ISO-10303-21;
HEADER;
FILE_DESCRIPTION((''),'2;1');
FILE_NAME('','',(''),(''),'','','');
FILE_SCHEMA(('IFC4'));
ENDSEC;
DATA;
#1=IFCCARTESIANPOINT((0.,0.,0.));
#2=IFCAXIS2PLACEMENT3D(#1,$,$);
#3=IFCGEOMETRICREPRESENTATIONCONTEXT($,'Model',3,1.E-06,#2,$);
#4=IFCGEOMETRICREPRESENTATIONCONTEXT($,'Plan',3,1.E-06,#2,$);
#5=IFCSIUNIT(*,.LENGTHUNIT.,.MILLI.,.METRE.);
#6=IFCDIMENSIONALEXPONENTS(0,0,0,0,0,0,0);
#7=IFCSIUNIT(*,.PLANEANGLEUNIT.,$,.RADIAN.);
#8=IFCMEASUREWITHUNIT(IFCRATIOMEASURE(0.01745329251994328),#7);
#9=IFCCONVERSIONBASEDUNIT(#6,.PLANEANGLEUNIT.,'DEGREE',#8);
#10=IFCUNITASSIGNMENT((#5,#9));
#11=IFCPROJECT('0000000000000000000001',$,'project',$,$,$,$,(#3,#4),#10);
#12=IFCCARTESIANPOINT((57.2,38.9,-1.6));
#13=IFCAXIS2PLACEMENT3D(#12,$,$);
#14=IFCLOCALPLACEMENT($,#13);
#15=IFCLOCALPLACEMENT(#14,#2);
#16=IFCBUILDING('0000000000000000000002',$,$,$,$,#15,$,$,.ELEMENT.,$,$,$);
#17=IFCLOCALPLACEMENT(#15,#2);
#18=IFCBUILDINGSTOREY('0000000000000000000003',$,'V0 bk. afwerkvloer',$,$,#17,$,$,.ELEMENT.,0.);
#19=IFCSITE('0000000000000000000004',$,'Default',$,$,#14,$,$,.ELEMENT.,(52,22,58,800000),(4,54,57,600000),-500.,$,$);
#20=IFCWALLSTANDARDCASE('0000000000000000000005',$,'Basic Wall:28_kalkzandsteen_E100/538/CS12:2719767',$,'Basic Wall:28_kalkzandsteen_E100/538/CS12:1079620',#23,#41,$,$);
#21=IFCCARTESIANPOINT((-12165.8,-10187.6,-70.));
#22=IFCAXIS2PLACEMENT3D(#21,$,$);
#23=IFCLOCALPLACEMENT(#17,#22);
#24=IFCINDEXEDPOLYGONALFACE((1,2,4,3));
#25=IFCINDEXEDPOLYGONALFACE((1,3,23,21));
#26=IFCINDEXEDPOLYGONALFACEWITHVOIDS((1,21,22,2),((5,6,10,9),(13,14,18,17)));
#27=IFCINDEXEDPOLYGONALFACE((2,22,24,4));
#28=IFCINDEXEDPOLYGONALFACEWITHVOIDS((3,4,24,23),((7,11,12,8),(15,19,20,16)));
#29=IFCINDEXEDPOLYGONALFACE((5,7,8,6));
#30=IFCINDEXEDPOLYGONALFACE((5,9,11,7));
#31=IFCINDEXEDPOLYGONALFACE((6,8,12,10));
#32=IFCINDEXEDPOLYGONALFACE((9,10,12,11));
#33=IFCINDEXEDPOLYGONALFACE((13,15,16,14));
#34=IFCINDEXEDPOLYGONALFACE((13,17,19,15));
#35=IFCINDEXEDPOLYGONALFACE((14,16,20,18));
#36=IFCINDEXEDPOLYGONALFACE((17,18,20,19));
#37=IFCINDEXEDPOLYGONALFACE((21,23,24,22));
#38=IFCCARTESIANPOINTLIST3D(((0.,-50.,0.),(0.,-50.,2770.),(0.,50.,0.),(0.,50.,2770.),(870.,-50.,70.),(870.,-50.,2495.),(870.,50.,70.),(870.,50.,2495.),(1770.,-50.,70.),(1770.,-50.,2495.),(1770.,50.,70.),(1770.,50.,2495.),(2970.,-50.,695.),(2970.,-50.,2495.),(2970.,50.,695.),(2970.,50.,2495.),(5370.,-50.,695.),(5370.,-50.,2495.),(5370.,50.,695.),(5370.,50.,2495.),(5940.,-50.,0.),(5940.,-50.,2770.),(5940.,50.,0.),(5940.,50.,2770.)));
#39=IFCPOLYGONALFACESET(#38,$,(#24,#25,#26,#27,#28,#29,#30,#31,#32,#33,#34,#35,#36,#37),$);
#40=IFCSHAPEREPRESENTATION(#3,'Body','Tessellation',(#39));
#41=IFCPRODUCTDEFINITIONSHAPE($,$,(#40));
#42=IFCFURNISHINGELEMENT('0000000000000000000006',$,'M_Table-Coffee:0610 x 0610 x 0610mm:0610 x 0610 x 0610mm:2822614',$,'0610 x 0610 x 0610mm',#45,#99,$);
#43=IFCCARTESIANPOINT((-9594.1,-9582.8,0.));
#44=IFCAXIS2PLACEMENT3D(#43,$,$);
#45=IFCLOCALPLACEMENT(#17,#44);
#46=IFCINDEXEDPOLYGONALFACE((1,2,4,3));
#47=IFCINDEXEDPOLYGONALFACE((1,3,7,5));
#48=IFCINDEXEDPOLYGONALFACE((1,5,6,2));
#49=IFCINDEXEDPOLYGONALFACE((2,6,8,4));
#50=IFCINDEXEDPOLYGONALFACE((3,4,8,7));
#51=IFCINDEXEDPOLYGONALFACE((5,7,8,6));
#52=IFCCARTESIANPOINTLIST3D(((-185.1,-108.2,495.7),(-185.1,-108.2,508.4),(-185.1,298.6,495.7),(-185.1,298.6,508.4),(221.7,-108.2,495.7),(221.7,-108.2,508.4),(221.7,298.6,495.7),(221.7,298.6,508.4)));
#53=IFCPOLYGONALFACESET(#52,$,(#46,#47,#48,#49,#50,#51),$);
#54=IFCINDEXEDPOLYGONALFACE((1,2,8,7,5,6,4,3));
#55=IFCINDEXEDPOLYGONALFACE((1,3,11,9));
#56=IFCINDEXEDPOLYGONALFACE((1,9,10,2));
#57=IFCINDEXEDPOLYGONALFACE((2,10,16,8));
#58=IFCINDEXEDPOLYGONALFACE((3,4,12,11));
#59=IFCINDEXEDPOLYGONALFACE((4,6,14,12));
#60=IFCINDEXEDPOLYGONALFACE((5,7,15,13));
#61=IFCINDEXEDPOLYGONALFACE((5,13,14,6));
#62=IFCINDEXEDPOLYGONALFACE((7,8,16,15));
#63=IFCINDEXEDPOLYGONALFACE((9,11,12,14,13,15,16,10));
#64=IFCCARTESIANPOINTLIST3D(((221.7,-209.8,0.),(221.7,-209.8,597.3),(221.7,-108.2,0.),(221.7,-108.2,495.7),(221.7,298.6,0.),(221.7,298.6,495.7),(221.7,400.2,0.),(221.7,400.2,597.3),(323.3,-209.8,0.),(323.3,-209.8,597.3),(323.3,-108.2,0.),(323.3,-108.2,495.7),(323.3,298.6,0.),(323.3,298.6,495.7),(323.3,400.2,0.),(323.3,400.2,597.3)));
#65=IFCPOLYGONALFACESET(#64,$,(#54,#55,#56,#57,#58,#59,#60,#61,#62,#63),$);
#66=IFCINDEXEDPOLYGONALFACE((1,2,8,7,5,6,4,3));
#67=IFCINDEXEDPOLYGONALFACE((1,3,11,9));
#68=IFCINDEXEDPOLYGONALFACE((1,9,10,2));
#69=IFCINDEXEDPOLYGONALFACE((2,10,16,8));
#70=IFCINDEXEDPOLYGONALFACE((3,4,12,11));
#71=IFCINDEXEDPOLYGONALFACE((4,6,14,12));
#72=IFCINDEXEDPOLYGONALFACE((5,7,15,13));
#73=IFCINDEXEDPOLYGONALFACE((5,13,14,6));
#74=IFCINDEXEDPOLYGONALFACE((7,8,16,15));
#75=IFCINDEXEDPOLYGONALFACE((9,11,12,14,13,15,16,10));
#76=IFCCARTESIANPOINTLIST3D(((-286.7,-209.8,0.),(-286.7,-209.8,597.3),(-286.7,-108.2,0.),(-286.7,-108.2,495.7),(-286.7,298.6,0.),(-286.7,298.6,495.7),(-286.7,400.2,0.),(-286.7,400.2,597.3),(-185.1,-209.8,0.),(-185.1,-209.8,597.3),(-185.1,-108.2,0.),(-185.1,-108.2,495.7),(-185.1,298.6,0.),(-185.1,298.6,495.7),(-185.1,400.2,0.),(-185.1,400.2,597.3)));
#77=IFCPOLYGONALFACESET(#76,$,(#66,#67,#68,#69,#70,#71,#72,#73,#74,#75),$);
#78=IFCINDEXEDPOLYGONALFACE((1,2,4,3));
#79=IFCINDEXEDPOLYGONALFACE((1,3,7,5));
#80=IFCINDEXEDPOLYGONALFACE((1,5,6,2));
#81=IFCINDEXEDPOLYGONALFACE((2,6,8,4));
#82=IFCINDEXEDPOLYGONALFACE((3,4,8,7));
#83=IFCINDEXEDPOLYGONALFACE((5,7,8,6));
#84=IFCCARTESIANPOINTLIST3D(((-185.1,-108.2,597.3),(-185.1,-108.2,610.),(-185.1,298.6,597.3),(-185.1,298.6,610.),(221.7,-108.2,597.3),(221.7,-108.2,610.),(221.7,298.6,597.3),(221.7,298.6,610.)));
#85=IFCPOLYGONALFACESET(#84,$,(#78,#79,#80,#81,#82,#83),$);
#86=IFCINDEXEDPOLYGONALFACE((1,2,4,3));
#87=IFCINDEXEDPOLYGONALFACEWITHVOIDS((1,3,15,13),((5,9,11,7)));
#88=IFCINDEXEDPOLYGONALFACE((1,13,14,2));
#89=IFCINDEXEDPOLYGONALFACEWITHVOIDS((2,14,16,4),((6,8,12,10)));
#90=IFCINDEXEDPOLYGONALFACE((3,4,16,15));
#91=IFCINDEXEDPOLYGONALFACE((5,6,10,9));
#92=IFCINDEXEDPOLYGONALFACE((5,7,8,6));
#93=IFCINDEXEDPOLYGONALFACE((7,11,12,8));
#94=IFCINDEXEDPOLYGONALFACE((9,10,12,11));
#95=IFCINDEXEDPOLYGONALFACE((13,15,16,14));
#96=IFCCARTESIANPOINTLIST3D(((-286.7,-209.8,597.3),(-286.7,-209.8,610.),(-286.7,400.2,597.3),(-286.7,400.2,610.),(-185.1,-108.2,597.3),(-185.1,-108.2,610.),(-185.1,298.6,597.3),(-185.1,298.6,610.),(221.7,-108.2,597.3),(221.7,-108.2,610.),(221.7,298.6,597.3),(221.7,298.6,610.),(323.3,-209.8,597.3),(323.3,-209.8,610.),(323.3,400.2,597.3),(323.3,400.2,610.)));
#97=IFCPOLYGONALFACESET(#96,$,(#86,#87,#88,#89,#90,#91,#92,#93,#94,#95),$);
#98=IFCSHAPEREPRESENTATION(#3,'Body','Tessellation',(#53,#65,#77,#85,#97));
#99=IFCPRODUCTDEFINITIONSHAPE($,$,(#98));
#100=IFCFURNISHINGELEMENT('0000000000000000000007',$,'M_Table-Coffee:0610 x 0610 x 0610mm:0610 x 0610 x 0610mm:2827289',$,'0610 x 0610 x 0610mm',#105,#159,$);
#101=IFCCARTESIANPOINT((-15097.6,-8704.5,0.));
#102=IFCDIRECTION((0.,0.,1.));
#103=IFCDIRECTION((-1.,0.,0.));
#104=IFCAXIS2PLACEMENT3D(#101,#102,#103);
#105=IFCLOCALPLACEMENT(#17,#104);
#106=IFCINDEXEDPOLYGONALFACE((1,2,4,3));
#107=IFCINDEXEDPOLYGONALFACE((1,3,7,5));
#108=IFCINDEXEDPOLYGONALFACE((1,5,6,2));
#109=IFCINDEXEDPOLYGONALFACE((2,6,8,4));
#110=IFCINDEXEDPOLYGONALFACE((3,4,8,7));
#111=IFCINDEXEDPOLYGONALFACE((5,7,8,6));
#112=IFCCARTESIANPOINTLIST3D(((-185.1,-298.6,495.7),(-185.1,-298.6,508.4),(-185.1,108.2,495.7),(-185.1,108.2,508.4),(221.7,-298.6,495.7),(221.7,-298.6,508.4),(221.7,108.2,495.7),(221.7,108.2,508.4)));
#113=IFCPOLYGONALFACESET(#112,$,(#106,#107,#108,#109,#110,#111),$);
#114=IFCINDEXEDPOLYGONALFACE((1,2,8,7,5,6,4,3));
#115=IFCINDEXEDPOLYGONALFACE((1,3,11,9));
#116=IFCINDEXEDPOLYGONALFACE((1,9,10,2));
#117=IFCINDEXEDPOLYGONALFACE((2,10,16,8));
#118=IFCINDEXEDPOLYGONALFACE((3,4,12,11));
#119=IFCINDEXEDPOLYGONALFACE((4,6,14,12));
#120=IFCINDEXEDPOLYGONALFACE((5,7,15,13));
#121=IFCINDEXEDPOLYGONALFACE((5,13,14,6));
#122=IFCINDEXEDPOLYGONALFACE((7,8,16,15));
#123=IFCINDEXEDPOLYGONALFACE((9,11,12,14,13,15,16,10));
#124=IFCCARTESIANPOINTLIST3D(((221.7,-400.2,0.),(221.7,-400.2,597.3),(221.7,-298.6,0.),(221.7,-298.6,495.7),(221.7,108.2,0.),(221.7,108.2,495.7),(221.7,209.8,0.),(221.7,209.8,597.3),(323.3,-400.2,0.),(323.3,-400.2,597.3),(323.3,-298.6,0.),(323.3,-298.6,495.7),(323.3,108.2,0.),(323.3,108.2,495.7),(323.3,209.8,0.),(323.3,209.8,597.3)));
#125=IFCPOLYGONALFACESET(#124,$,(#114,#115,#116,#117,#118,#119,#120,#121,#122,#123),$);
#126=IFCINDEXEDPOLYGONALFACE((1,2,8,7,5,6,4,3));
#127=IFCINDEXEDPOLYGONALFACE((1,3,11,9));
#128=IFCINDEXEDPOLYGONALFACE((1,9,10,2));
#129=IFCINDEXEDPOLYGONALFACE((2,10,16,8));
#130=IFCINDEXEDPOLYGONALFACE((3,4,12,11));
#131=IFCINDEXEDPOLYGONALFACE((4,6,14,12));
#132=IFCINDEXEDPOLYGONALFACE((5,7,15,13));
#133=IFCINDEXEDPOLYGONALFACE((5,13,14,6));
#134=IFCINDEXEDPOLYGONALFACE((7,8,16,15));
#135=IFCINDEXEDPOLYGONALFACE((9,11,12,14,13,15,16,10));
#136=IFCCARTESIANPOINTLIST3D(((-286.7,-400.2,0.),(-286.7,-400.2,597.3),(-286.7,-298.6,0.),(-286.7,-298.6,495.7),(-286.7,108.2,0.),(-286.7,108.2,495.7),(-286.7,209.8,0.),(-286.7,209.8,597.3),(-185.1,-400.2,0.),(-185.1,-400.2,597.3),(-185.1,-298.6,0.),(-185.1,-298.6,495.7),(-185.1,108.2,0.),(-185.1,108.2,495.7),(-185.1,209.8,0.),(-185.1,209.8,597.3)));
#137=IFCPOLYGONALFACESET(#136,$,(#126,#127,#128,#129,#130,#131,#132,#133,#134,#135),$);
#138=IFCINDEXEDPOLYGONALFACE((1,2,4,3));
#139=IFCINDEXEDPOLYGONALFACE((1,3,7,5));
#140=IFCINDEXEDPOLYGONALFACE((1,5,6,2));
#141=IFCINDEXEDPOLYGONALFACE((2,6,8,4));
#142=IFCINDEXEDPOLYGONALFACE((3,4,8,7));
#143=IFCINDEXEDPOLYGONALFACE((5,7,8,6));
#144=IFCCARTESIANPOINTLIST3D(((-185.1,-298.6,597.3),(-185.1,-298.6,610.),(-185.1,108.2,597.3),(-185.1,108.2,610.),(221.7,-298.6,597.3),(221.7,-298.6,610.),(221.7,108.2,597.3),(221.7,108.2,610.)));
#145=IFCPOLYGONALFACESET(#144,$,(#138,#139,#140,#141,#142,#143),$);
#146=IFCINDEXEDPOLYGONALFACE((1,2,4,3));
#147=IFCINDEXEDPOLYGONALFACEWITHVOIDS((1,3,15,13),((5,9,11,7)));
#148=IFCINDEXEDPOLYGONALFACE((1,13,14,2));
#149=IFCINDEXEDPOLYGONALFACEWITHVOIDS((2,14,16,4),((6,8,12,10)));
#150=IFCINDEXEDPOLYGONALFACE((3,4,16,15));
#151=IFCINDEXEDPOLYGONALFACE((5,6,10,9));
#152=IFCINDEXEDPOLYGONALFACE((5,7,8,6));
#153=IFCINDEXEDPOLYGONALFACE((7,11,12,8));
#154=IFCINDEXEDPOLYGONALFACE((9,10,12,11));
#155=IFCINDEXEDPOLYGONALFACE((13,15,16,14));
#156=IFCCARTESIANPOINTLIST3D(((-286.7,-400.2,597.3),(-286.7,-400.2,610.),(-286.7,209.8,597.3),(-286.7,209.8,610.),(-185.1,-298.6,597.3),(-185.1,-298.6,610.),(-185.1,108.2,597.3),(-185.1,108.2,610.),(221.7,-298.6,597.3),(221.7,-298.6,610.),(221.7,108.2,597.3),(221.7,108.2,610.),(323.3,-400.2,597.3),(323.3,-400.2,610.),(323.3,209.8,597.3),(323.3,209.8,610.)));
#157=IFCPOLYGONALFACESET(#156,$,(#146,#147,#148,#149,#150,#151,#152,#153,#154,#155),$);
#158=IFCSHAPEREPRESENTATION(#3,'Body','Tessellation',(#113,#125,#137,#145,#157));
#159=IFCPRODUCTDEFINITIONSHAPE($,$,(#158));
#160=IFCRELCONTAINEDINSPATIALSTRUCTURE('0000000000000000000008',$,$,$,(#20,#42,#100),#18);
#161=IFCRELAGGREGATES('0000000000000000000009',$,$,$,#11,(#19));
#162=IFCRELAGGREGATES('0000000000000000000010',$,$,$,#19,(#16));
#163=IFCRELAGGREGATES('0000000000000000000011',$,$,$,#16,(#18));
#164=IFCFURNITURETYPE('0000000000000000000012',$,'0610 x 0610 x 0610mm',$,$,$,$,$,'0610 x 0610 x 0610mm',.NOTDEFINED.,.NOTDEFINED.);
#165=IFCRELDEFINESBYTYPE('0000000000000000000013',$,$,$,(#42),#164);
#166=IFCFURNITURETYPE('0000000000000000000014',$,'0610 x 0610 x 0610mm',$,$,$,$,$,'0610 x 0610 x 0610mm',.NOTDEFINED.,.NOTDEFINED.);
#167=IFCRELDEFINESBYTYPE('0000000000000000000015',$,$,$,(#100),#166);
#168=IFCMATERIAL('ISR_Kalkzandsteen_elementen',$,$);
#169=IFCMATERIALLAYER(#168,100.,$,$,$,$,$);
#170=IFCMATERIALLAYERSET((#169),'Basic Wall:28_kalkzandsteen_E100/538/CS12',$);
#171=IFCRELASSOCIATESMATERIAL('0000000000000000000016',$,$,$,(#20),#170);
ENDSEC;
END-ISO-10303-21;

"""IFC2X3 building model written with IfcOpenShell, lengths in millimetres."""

from ifc_helpers import new_model, entity, si_unit, converted_unit, frame, frame_2d, origin, origin_2d_with_axis, place, context, project, spatial, polyline, rectangle, outline, extrude, source, transform, mapped, material, layer, layer_set, layer_usage, type_object, type_shapes, element, save


model = new_model("IFC2X3")

# Units and contexts
model_context = context("Model", 3, precision=1e-06, world=origin())
plan_context = context("Plan", 3, precision=1e-06, world=origin())
ifc_project = project(units=[si_unit("LENGTHUNIT", "METRE", prefix="MILLI"), converted_unit("PLANEANGLEUNIT", "DEGREE", entity("IfcRatioMeasure", 0.01745329251994328), si_unit("PLANEANGLEUNIT", "RADIAN"), dimensions=[0, 0, 0, 0, 0, 0, 0])], contexts=[model_context, plan_context])

# Site, building, storey
site_placement = place(None, frame((57.2, 38.9, -1.6)))
site = spatial("IfcSite", under=ifc_project, at=site_placement, Name="Default", CompositionType="ELEMENT", RefLatitude=(52, 22, 58, 800000), RefLongitude=(4, 54, 57, 600000), RefElevation=-500.0)
building_placement = place(site_placement, origin())
building = spatial("IfcBuilding", under=site, at=building_placement, CompositionType="ELEMENT")
storey_placement = place(building_placement, origin())
storey = spatial("IfcBuildingStorey", under=building, at=storey_placement, Name="V0 bk. afwerkvloer", CompositionType="ELEMENT", Elevation=0.0)

# Wall, openings
ifc_material = material(Name="ISR_Kalkzandsteen_elementen")
ifc_layer_1 = layer(ifc_material, 100.0)
ifc_layer_set_1 = layer_set([ifc_layer_1], Name="Basic Wall:28_kalkzandsteen_E100/538/CS12")
ifc_layer_usage_1 = layer_usage(ifc_layer_set_1, "AXIS2", "NEGATIVE", 50.0)
wall_1_placement = place(storey_placement, frame((-12165.8, -10187.6, -70.0)))
wall_1 = element("IfcWallStandardCase", 1, at=wall_1_placement, inside=storey, material=ifc_layer_usage_1, Name="Basic Wall:28_kalkzandsteen_E100/538/CS12:2719767", ObjectType="Basic Wall:28_kalkzandsteen_E100/538/CS12:1079620", context=model_context, shape_type="SweptSolid", body=[
    extrude(rectangle(XDim=5940.0, YDim=100.0, at=frame_2d((2970.0, 0.0), x_axis=(-1.0, 0.0))), origin(), (0.0, 0.0, 1.0), 2770.0),
])
opening_1_placement = place(wall_1_placement, origin())
element("IfcOpeningElement", 2, at=opening_1_placement, cuts=wall_1, ObjectType="Opening", context=model_context, shape_type="SweptSolid", body=[
    extrude(rectangle(XDim=1800.0, YDim=2400.0, at=origin_2d_with_axis()), frame((4170.0, -202.4, 1595.0), z_axis=(0.0, 1.0, 0.0), x_axis=(0.0, 0.0, 1.0)), (0.0, 0.0, 1.0), 404.8),
])
opening_2_placement = place(wall_1_placement, origin())
element("IfcOpeningElement", 3, at=opening_2_placement, cuts=wall_1, ObjectType="Opening", context=model_context, shape_type="SweptSolid", body=[
    extrude(rectangle(XDim=2425.0, YDim=900.0, at=origin_2d_with_axis()), frame((1320.0, -202.4, 1282.5), z_axis=(0.0, 1.0, 0.0), x_axis=(0.0, 0.0, 1.0)), (0.0, 0.0, 1.0), 404.8),
])

# Furnishing elements
furniture_type_1 = type_object("IfcFurnitureType", Name="0610 x 0610 x 0610mm", ElementType="0610 x 0610 x 0610mm", AssemblyPlace="NOTDEFINED")
shared_shape_1 = source(origin(), model_context, "Body", "SweptSolid", [
    extrude(rectangle(XDim=406.8, YDim=406.8, at=origin_2d_with_axis()), frame((18.3, 95.2, 495.7), z_axis=(0.0, 0.0, 1.0), x_axis=(-1.0, 0.0, 0.0)), (0.0, 0.0, 1.0), 12.7),
    extrude(outline(polyline([(-273.2, -305.0), (324.0, -305.0), (324.0, 305.0), (-273.2, 305.0), (-273.2, 203.4), (222.5, 203.4), (222.5, -203.4), (-273.2, -203.4), (-273.2, -305.0)])), frame((221.7, 95.2, 273.2), z_axis=(1.0, 0.0, 0.0), x_axis=(0.0, 0.0, 1.0)), (0.0, 0.0, 1.0), 101.6),
    extrude(outline(polyline([(-305.0, -324.1), (305.0, -324.1), (305.0, 273.3), (203.4, 273.3), (203.4, -222.4), (-203.4, -222.4), (-203.4, 273.3), (-305.0, 273.3), (-305.0, -324.1)])), frame((-286.7, 95.2, 273.3), z_axis=(1.0, 0.0, 0.0), x_axis=(0.0, -1.0, 0.0)), (0.0, 0.0, 1.0), 101.6),
    extrude(rectangle(XDim=406.8, YDim=406.8, at=origin_2d_with_axis()), frame((18.3, 95.2, 597.3), z_axis=(0.0, 0.0, 1.0), x_axis=(-1.0, 0.0, 0.0)), (0.0, 0.0, 1.0), 12.7),
    extrude(outline(polyline([(-305.0, -305.0), (305.0, -305.0), (305.0, 305.0), (-305.0, 305.0), (-305.0, -305.0)]), holes=[polyline([(-203.4, -203.4), (-203.4, 203.4), (203.4, 203.4), (203.4, -203.4), (-203.4, -203.4)])]), frame((18.3, 95.2, 597.3), z_axis=(0.0, 0.0, 1.0), x_axis=(-1.0, 0.0, 0.0)), (0.0, 0.0, 1.0), 12.7),
])
type_shapes(furniture_type_1, [shared_shape_1])
furnishing_1_placement = place(storey_placement, frame((-9594.1, -9582.8, 0.0)))
element("IfcFurnishingElement", 4, at=furnishing_1_placement, inside=storey, type_object=furniture_type_1, Name="M_Table-Coffee:0610 x 0610 x 0610mm:0610 x 0610 x 0610mm:2822614", ObjectType="0610 x 0610 x 0610mm", context=model_context, shape_type="MappedRepresentation", body=[
    mapped(shared_shape_1, transform((0.0, 0.0, 0.0), scale=1.0)),
])
furniture_type_2 = type_object("IfcFurnitureType", Name="0610 x 0610 x 0610mm", ElementType="0610 x 0610 x 0610mm", AssemblyPlace="NOTDEFINED")
shared_shape_2 = source(origin(), model_context, "Body", "SweptSolid", [
    extrude(rectangle(XDim=406.8, YDim=406.8, at=origin_2d_with_axis()), frame((18.3, -95.2, 495.7), z_axis=(0.0, 0.0, 1.0), x_axis=(0.0, 1.0, 0.0)), (0.0, 0.0, 1.0), 12.7),
    extrude(outline(polyline([(-305.0, -273.2), (-203.4, -273.2), (-203.4, 222.5), (203.4, 222.5), (203.4, -273.2), (305.0, -273.2), (305.0, 324.0), (-305.0, 324.0), (-305.0, -273.2)])), frame((221.7, -95.2, 273.2), z_axis=(1.0, 0.0, 0.0), x_axis=(0.0, 1.0, 0.0)), (0.0, 0.0, 1.0), 101.6),
    extrude(outline(polyline([(-324.1, -305.0), (273.3, -305.0), (273.3, -203.4), (-222.4, -203.4), (-222.4, 203.4), (273.3, 203.4), (273.3, 305.0), (-324.1, 305.0), (-324.1, -305.0)])), frame((-286.7, -95.2, 273.3), z_axis=(1.0, 0.0, 0.0), x_axis=(0.0, 0.0, -1.0)), (0.0, 0.0, 1.0), 101.6),
    extrude(rectangle(XDim=406.8, YDim=406.8, at=origin_2d_with_axis()), frame((18.3, -95.2, 597.3), z_axis=(0.0, 0.0, 1.0), x_axis=(0.0, 1.0, 0.0)), (0.0, 0.0, 1.0), 12.7),
    extrude(outline(polyline([(-305.0, -305.0), (305.0, -305.0), (305.0, 305.0), (-305.0, 305.0), (-305.0, -305.0)]), holes=[polyline([(-203.4, -203.4), (-203.4, 203.4), (203.4, 203.4), (203.4, -203.4), (-203.4, -203.4)])]), frame((18.3, -95.2, 597.3), z_axis=(0.0, 0.0, 1.0), x_axis=(0.0, 1.0, 0.0)), (0.0, 0.0, 1.0), 12.7),
])
type_shapes(furniture_type_2, [shared_shape_2])
furnishing_2_placement = place(storey_placement, frame((-15097.6, -8704.5, 0.0), z_axis=(0.0, 0.0, 1.0), x_axis=(-1.0, 0.0, 0.0)))
element("IfcFurnishingElement", 5, at=furnishing_2_placement, inside=storey, type_object=furniture_type_2, Name="M_Table-Coffee:0610 x 0610 x 0610mm:0610 x 0610 x 0610mm:2827289", ObjectType="0610 x 0610 x 0610mm", context=model_context, shape_type="MappedRepresentation", body=[
    mapped(shared_shape_2, transform((0.0, 0.0, 0.0), scale=1.0)),
])

save(model, "model.ifc")
